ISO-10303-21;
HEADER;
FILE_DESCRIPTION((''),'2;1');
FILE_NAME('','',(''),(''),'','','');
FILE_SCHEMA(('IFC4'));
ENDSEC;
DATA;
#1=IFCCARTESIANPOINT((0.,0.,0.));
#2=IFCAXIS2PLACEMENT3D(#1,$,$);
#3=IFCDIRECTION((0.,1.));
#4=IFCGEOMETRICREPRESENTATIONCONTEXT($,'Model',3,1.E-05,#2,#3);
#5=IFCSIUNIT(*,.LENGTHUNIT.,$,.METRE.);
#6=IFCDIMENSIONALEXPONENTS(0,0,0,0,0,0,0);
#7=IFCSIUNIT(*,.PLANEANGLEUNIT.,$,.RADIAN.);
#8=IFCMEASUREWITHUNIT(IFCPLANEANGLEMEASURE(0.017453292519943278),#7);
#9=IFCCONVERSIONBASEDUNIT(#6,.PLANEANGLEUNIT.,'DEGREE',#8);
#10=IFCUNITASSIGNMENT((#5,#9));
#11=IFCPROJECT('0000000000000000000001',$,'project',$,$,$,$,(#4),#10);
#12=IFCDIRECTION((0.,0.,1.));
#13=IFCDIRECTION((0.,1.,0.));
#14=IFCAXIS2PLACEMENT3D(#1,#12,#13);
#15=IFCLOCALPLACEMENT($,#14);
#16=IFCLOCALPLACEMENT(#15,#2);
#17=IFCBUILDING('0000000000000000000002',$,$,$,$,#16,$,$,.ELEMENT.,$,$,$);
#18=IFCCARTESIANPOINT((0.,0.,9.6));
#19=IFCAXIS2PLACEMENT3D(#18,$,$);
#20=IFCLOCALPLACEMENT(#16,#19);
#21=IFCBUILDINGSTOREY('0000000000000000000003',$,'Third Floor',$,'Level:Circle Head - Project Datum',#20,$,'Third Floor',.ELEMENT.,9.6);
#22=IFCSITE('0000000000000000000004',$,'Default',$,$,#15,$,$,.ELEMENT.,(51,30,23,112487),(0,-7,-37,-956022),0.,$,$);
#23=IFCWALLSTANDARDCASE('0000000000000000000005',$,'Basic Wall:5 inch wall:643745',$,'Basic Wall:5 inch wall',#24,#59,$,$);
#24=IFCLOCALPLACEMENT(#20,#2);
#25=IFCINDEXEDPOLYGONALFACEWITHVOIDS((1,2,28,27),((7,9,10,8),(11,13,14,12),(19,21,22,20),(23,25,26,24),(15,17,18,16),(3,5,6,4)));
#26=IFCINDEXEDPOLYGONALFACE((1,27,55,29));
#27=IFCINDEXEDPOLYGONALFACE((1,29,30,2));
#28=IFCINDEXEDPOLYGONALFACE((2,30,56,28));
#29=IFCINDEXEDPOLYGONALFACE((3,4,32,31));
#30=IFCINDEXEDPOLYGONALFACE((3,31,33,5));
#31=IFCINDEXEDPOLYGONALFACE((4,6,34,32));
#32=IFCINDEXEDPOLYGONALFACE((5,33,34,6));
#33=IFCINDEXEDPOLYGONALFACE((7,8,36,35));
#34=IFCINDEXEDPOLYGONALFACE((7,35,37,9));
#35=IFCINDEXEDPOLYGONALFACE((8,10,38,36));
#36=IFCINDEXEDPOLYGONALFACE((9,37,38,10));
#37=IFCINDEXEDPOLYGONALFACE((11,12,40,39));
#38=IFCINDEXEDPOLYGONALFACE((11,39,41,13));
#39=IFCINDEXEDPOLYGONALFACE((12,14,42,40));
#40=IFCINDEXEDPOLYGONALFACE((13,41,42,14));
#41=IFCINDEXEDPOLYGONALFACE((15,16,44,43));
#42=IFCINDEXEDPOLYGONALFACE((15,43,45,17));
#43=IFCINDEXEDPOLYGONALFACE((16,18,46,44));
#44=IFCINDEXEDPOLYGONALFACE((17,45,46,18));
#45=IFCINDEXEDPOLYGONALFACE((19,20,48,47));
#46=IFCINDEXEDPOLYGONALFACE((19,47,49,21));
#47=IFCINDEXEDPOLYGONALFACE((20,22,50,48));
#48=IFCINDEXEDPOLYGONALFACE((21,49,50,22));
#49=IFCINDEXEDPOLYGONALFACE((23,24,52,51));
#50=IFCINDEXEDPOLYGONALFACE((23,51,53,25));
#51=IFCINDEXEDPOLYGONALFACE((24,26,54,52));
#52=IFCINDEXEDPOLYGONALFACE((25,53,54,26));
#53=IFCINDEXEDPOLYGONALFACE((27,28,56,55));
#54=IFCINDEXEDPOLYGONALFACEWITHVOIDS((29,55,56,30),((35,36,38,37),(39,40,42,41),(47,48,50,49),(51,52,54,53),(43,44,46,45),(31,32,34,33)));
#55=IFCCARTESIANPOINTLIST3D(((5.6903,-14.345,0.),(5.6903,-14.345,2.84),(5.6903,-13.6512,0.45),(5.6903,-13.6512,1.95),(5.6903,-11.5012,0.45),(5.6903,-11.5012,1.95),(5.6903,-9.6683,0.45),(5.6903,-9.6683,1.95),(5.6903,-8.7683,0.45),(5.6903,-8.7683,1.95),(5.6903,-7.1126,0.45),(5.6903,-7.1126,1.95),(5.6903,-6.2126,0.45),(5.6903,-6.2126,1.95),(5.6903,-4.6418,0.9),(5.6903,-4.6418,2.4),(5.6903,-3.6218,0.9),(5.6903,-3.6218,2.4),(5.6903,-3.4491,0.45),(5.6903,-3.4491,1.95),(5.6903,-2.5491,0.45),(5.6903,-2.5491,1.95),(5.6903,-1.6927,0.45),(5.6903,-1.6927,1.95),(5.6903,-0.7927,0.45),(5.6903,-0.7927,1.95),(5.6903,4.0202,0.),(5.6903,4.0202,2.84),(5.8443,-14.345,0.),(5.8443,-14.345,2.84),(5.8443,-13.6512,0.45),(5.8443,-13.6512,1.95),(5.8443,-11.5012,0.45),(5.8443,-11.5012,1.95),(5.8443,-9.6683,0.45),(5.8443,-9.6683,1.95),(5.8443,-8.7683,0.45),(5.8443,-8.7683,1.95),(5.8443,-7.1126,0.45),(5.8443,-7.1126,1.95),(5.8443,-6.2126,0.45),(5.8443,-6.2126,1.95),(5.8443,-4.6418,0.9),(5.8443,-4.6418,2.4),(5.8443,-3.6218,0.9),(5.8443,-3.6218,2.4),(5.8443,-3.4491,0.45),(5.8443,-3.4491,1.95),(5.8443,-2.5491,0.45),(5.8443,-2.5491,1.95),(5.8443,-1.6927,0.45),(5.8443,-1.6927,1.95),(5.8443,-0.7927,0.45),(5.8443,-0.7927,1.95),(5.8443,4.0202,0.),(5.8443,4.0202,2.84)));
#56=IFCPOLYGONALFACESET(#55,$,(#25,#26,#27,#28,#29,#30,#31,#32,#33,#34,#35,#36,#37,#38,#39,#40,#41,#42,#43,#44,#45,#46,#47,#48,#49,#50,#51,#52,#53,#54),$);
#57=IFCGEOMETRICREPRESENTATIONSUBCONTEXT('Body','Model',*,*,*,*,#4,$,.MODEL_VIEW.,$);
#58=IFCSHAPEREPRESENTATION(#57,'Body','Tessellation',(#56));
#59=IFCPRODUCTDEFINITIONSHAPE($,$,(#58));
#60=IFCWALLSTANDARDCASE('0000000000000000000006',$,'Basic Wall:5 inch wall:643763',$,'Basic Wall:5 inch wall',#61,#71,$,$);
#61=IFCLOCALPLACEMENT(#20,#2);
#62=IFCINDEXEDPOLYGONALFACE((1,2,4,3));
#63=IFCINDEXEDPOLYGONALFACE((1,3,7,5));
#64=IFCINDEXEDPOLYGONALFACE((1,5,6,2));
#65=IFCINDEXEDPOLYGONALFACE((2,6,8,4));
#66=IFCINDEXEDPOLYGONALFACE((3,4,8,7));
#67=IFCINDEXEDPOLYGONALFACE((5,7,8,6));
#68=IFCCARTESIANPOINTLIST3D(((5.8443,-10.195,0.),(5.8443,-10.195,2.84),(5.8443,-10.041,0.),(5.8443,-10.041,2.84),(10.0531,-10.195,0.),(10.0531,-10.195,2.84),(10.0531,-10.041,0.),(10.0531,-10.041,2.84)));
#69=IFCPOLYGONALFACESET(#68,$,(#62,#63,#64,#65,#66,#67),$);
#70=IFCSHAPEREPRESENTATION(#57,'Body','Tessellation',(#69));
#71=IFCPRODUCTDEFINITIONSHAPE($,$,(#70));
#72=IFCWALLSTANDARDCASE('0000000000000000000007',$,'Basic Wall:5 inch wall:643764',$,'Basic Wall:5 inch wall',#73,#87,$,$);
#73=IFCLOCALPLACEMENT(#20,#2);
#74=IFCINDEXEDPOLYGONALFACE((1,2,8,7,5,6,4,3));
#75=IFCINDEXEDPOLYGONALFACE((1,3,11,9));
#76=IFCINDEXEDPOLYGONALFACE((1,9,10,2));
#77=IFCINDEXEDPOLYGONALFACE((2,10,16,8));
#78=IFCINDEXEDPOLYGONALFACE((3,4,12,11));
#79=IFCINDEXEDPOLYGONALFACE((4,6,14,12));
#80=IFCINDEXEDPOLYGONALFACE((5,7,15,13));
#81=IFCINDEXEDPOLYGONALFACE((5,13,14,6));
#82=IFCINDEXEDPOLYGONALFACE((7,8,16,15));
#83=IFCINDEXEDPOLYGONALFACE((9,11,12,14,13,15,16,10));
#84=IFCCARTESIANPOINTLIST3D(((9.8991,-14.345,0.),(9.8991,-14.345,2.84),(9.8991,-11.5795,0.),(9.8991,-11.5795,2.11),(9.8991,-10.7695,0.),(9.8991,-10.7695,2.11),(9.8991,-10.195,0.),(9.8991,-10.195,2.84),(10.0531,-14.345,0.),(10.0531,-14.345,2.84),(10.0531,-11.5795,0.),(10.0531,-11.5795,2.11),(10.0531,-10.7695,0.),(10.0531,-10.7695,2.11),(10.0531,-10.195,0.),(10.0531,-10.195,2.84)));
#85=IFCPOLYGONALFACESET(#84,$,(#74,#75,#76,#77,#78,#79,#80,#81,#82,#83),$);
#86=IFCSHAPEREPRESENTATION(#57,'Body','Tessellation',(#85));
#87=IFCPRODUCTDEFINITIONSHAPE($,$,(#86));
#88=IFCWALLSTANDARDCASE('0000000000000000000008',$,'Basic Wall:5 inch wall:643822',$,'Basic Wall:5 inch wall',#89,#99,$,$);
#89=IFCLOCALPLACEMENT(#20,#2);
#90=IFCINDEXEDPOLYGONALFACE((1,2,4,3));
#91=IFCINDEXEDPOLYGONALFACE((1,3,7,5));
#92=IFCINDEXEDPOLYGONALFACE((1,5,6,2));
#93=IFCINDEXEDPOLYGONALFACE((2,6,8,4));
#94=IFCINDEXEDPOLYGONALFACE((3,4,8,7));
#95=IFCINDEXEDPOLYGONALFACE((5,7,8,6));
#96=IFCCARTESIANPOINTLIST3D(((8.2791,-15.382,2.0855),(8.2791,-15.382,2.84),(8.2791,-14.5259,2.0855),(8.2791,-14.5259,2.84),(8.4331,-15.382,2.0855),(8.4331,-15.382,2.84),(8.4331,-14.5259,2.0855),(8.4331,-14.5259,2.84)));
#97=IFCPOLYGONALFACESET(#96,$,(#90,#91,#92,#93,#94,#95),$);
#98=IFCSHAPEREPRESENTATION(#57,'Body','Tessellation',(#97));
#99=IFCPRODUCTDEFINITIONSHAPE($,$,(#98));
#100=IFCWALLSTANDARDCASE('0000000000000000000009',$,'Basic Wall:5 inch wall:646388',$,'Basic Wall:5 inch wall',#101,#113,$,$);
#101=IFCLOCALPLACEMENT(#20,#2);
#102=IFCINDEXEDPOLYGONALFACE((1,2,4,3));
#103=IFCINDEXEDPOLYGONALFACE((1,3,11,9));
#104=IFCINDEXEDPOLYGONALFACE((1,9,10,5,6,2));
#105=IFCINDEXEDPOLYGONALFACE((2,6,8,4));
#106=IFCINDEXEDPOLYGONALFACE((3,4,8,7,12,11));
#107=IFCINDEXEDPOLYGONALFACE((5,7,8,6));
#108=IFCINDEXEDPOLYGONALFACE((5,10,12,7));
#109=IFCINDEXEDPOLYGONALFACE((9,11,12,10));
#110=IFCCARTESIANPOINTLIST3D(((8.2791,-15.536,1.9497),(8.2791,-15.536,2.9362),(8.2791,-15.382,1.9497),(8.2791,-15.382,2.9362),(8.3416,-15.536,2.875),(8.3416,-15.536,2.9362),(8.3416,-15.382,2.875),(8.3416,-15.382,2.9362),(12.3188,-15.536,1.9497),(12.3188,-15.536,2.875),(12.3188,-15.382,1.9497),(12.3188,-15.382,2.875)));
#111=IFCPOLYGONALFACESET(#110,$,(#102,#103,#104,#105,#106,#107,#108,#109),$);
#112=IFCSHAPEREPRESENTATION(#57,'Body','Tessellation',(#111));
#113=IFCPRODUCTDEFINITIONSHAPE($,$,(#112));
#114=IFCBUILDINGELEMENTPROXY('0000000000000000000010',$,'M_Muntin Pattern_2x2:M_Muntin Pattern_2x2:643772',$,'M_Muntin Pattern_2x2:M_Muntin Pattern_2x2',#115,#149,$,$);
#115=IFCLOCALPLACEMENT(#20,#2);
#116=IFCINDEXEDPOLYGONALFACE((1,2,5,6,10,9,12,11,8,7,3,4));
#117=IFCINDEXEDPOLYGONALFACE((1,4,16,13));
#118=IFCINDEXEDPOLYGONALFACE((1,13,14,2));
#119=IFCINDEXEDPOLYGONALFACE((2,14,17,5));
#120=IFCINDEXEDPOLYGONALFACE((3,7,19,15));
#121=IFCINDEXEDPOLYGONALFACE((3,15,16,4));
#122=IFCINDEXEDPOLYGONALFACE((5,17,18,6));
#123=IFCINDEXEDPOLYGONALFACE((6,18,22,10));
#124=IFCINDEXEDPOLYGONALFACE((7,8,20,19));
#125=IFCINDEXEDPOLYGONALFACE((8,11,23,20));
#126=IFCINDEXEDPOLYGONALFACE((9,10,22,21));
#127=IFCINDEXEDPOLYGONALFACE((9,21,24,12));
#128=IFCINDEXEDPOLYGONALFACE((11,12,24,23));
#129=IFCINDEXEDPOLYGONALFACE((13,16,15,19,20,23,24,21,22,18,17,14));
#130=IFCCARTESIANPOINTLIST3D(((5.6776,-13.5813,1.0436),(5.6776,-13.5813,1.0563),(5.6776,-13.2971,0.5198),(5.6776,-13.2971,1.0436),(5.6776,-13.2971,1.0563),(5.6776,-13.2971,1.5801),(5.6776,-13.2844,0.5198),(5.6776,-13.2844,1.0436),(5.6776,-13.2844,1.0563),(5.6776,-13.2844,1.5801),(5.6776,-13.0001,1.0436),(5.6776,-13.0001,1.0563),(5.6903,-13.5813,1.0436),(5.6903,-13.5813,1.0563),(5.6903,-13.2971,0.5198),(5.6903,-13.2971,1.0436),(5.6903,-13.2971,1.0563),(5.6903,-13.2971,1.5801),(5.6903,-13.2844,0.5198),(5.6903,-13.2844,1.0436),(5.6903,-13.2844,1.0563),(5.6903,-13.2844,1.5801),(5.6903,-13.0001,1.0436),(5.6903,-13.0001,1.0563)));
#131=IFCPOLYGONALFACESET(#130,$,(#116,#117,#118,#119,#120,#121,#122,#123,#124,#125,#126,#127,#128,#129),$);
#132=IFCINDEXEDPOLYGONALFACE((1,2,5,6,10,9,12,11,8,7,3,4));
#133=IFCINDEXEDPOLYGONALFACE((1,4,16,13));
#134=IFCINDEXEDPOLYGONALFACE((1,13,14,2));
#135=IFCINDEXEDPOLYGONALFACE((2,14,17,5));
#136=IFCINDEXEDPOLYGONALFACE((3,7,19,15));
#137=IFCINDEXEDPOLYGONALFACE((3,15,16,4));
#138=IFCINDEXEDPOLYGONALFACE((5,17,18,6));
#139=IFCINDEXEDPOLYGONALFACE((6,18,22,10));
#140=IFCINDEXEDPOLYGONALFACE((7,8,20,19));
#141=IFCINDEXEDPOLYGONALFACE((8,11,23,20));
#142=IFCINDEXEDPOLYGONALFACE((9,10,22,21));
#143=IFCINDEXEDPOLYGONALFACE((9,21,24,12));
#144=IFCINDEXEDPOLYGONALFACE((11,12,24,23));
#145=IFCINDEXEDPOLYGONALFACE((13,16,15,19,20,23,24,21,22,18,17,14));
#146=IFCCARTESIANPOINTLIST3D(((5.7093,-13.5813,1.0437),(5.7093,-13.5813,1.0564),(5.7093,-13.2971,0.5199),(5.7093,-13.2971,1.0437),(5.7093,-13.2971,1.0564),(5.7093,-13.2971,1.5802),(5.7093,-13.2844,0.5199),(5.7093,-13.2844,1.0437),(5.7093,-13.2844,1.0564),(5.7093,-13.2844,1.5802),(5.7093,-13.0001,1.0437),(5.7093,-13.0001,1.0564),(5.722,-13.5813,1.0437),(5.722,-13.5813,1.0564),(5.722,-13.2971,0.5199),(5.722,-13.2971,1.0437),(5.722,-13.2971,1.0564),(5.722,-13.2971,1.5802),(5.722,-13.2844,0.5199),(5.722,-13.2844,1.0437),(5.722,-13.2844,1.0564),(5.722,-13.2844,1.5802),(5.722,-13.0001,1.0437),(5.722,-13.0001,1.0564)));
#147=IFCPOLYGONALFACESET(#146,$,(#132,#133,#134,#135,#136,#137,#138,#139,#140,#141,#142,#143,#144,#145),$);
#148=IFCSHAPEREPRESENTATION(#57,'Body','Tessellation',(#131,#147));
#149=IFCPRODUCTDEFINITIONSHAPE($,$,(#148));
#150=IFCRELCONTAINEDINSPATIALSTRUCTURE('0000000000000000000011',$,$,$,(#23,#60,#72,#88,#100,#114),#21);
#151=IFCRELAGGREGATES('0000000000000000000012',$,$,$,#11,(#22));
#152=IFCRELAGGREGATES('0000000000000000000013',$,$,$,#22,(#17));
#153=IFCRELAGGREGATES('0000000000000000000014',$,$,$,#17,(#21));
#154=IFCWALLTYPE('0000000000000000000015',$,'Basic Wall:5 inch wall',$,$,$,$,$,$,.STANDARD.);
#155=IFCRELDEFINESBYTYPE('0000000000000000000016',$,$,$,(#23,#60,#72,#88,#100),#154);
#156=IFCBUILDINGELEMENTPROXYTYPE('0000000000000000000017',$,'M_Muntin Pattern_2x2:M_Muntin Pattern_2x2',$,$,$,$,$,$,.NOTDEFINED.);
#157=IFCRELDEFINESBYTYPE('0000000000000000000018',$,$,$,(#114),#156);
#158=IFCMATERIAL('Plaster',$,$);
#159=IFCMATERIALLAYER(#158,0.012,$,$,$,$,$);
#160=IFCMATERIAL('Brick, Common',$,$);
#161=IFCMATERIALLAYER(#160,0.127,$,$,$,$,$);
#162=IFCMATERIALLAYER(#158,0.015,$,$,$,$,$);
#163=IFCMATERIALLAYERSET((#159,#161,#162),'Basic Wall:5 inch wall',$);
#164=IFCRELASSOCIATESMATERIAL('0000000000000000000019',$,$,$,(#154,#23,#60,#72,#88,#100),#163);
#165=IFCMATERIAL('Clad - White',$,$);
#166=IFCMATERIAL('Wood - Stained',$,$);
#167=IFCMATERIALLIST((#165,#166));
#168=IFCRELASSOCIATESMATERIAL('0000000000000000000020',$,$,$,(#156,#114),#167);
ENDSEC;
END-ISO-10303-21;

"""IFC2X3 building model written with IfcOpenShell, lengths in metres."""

from ifc_helpers import new_model, entity, si_unit, converted_unit, direction, frame, frame_2d, origin, place, context, subcontext, project, spatial, polyline, rectangle, outline, extrude, clip, bounded_halfspace, source, transform, mapped, material, material_list, layer, layer_set, layer_usage, type_object, type_shapes, element, save


model = new_model("IFC2X3")

# Units and contexts
model_context = context("Model", 3, precision=1e-05, world=origin(), true_north=direction((0.0, 1.0)))
body_context = subcontext(model_context, "Body", "Model", "MODEL_VIEW")
ifc_project = project(units=[si_unit("LENGTHUNIT", "METRE"), converted_unit("PLANEANGLEUNIT", "DEGREE", entity("IfcPlaneAngleMeasure", 0.017453292519943278), si_unit("PLANEANGLEUNIT", "RADIAN"), dimensions=[0, 0, 0, 0, 0, 0, 0])], contexts=[model_context])

# Site, building, storey
site_placement = place(None, frame((0.0, 0.0, 0.0), z_axis=(0.0, 0.0, 1.0), x_axis=(0.0, 1.0, 0.0)))
site = spatial("IfcSite", under=ifc_project, at=site_placement, Name="Default", CompositionType="ELEMENT", RefLatitude=(51, 30, 23, 112487), RefLongitude=(0, -7, -37, -956022), RefElevation=0.0)
building_placement = place(site_placement, origin())
building = spatial("IfcBuilding", under=site, at=building_placement, CompositionType="ELEMENT")
storey_placement = place(building_placement, frame((0.0, 0.0, 9.6)))
storey = spatial("IfcBuildingStorey", under=building, at=storey_placement, Name="Third Floor", ObjectType="Level:Circle Head - Project Datum", LongName="Third Floor", CompositionType="ELEMENT", Elevation=9.6)

# Wall, openings
ifc_material_1 = material(Name="Plaster")
ifc_layer_1 = layer(ifc_material_1, 0.012)
ifc_material_2 = material(Name="Brick, Common")
ifc_layer_2 = layer(ifc_material_2, 0.127)
ifc_layer_3 = layer(ifc_material_1, 0.015)
ifc_layer_set = layer_set([ifc_layer_1, ifc_layer_2, ifc_layer_3], Name="Basic Wall:5 inch wall")
ifc_layer_usage_1 = layer_usage(ifc_layer_set, "AXIS2", "NEGATIVE", 0.077)
wall_type = type_object("IfcWallType", Name="Basic Wall:5 inch wall", PredefinedType="STANDARD", material=ifc_layer_set)
wall_1_placement = place(storey_placement, frame((5.7673, -14.345, 0.0), z_axis=(0.0, 0.0, 1.0), x_axis=(0.0, 1.0, 0.0)))
wall_1 = element("IfcWallStandardCase", 1, at=wall_1_placement, inside=storey, type_object=wall_type, material=ifc_layer_usage_1, Name="Basic Wall:5 inch wall:643745", ObjectType="Basic Wall:5 inch wall", context=body_context, shape_type="SweptSolid", body=[
    extrude(rectangle(XDim=18.3652, YDim=0.154, at=frame_2d((9.1826, 0.0), x_axis=(-1.0, 0.0))), origin(), (0.0, 0.0, 1.0), 2.84),
])
opening_1_placement = place(wall_1_placement, frame((0.6938, -0.077, 0.45)))
element("IfcOpeningElement", 2, at=opening_1_placement, cuts=wall_1, ObjectType="Opening", context=body_context, shape_type="SweptSolid", body=[
    extrude(rectangle(XDim=1.5, YDim=2.15, at=frame_2d((0.75, 1.075), x_axis=(-1.0, 0.0))), frame((0.0, 0.0, 0.0), z_axis=(0.0, 1.0, 0.0), x_axis=(0.0, 0.0, 1.0)), (0.0, 0.0, 1.0), 0.154),
])
opening_2_placement = place(wall_1_placement, frame((4.6767, -0.077, 0.45)))
element("IfcOpeningElement", 3, at=opening_2_placement, cuts=wall_1, ObjectType="Opening", context=body_context, shape_type="SweptSolid", body=[
    extrude(rectangle(XDim=1.5, YDim=0.9, at=frame_2d((0.75, 0.45), x_axis=(-1.0, 0.0))), frame((0.0, 0.0, 0.0), z_axis=(0.0, 1.0, 0.0), x_axis=(0.0, 0.0, 1.0)), (0.0, 0.0, 1.0), 0.154),
])
opening_3_placement = place(wall_1_placement, frame((7.2323, -0.077, 0.45)))
element("IfcOpeningElement", 4, at=opening_3_placement, cuts=wall_1, ObjectType="Opening", context=body_context, shape_type="SweptSolid", body=[
    extrude(rectangle(XDim=1.5, YDim=0.9, at=frame_2d((0.75, 0.45), x_axis=(-1.0, 0.0))), frame((0.0, 0.0, 0.0), z_axis=(0.0, 1.0, 0.0), x_axis=(0.0, 0.0, 1.0)), (0.0, 0.0, 1.0), 0.154),
])
opening_4_placement = place(wall_1_placement, frame((10.8959, -0.077, 0.45)))
element("IfcOpeningElement", 5, at=opening_4_placement, cuts=wall_1, ObjectType="Opening", context=body_context, shape_type="SweptSolid", body=[
    extrude(rectangle(XDim=1.5, YDim=0.9, at=frame_2d((0.75, 0.45), x_axis=(-1.0, 0.0))), frame((0.0, 0.0, 0.0), z_axis=(0.0, 1.0, 0.0), x_axis=(0.0, 0.0, 1.0)), (0.0, 0.0, 1.0), 0.154),
])
opening_5_placement = place(wall_1_placement, frame((12.6523, -0.077, 0.45)))
element("IfcOpeningElement", 6, at=opening_5_placement, cuts=wall_1, ObjectType="Opening", context=body_context, shape_type="SweptSolid", body=[
    extrude(rectangle(XDim=1.5, YDim=0.9, at=frame_2d((0.75, 0.45), x_axis=(-1.0, 0.0))), frame((0.0, 0.0, 0.0), z_axis=(0.0, 1.0, 0.0), x_axis=(0.0, 0.0, 1.0)), (0.0, 0.0, 1.0), 0.154),
])
opening_6_placement = place(wall_1_placement, frame((9.7032, -0.077, 0.9)))
element("IfcOpeningElement", 7, at=opening_6_placement, cuts=wall_1, ObjectType="Opening", context=body_context, shape_type="SweptSolid", body=[
    extrude(rectangle(XDim=1.5, YDim=1.02, at=frame_2d((0.75, 0.51), x_axis=(-1.0, 0.0))), frame((0.0, 0.0, 0.0), z_axis=(0.0, 1.0, 0.0), x_axis=(0.0, 0.0, 1.0)), (0.0, 0.0, 1.0), 0.154),
])

# Wall
ifc_layer_usage_2 = layer_usage(ifc_layer_set, "AXIS2", "POSITIVE", -0.077)
wall_2_placement = place(storey_placement, frame((5.8443, -10.118, 0.0)))
element("IfcWallStandardCase", 8, at=wall_2_placement, inside=storey, type_object=wall_type, material=ifc_layer_usage_2, Name="Basic Wall:5 inch wall:643763", ObjectType="Basic Wall:5 inch wall", context=body_context, shape_type="SweptSolid", body=[
    extrude(rectangle(XDim=4.2088, YDim=0.154, at=frame_2d((2.1044, 0.0), x_axis=(-1.0, 0.0))), origin(), (0.0, 0.0, 1.0), 2.84),
])

# Wall, opening
ifc_layer_usage_3 = layer_usage(ifc_layer_set, "AXIS2", "NEGATIVE", 0.077)
wall_3_placement = place(storey_placement, frame((9.9761, -10.195, 0.0), z_axis=(0.0, 0.0, 1.0), x_axis=(0.0, -1.0, 0.0)))
wall_3 = element("IfcWallStandardCase", 9, at=wall_3_placement, inside=storey, type_object=wall_type, material=ifc_layer_usage_3, Name="Basic Wall:5 inch wall:643764", ObjectType="Basic Wall:5 inch wall", context=body_context, shape_type="SweptSolid", body=[
    extrude(rectangle(XDim=4.15, YDim=0.154, at=frame_2d((2.075, 0.0), x_axis=(1.0, 0.0))), origin(), (0.0, 0.0, 1.0), 2.84),
])
opening_7_placement = place(wall_3_placement, frame((1.3845, 0.077, 0.0)))
element("IfcOpeningElement", 10, at=opening_7_placement, cuts=wall_3, ObjectType="Opening", context=body_context, shape_type="SweptSolid", body=[
    extrude(rectangle(XDim=2.11, YDim=0.81, at=frame_2d((1.055, 0.405), x_axis=(1.0, 0.0))), frame((0.0, 0.0, 0.0), z_axis=(0.0, -1.0, 0.0), x_axis=(0.0, 0.0, 1.0)), (0.0, 0.0, 1.0), 0.154),
])

# Walls
ifc_layer_usage_4 = layer_usage(ifc_layer_set, "AXIS2", "NEGATIVE", 0.077)
wall_4_placement = place(storey_placement, frame((8.3561, -14.5259, 2.0855), z_axis=(0.0, 0.0, 1.0), x_axis=(0.0, -1.0, 0.0)))
element("IfcWallStandardCase", 11, at=wall_4_placement, inside=storey, type_object=wall_type, material=ifc_layer_usage_4, Name="Basic Wall:5 inch wall:643822", ObjectType="Basic Wall:5 inch wall", context=body_context, shape_type="SweptSolid", body=[
    extrude(rectangle(XDim=0.8561, YDim=0.154, at=frame_2d((0.4281, 0.0), x_axis=(-1.0, 0.0))), origin(), (0.0, 0.0, 1.0), 0.7545),
])
ifc_layer_usage_5 = layer_usage(ifc_layer_set, "AXIS2", "NEGATIVE", 0.077)
wall_5_placement = place(storey_placement, frame((8.2791, -15.459, 1.9497)))
element("IfcWallStandardCase", 12, at=wall_5_placement, inside=storey, type_object=wall_type, material=ifc_layer_usage_5, Name="Basic Wall:5 inch wall:646388", ObjectType="Basic Wall:5 inch wall", context=body_context, shape_type="Clipping", body=[
    clip(extrude(rectangle(XDim=4.0398, YDim=0.154, at=frame_2d((2.0199, 0.0), x_axis=(-1.0, 0.0))), origin(), (0.0, 0.0, 1.0), 0.9865), bounded_halfspace(frame((0.0626, -0.077, 0.9253), z_axis=(0.0, 0.0, -1.0), x_axis=(0.0, -1.0, 0.0)), True, frame((0.0626, -0.077, 0.9253)), polyline([(0.0, 0.0), (3.9772, 0.0), (3.9772, 0.154), (0.0, 0.154), (0.0, 0.0)]))),
])

# Building element proxy
ifc_material_3 = material(Name="Clad - White")
ifc_material_4 = material(Name="Wood - Stained")
ifc_material_list = material_list([ifc_material_3, ifc_material_4])
building_element_proxy_type_1 = type_object("IfcBuildingElementProxyType", Name="M_Muntin Pattern_2x2:M_Muntin Pattern_2x2", PredefinedType="NOTDEFINED", material=ifc_material_list)
shared_shape_1 = source(origin(), body_context, "Body", "SweptSolid", [
    extrude(outline(polyline([(0.0064, -0.0064), (0.5301, -0.0064), (0.5301, 0.0063), (0.0064, 0.0063), (0.0064, 0.2906), (-0.0063, 0.2906), (-0.0063, 0.0063), (-0.5302, 0.0063), (-0.5302, -0.0064), (-0.0063, -0.0064), (-0.0063, -0.2906), (0.0064, -0.2906), (0.0064, -0.0064)])), frame((0.0, 0.0095, 0.5301), z_axis=(0.0, 1.0, 0.0), x_axis=(0.0, 0.0, 1.0)), (0.0, 0.0, 1.0), 0.0127),
    extrude(outline(polyline([(0.0064, -0.0064), (0.5302, -0.0064), (0.5302, 0.0063), (0.0064, 0.0063), (0.0064, 0.2906), (-0.0063, 0.2906), (-0.0063, 0.0063), (-0.5302, 0.0063), (-0.5302, -0.0064), (-0.0063, -0.0064), (-0.0063, -0.2906), (0.0064, -0.2906), (0.0064, -0.0064)])), frame((0.0, -0.0222, 0.5302), z_axis=(0.0, 1.0, 0.0), x_axis=(0.0, 0.0, 1.0)), (0.0, 0.0, 1.0), 0.0127),
])
type_shapes(building_element_proxy_type_1, [shared_shape_1])
proxy_1_placement = place(storey_placement, frame((5.6998, -13.2907, 0.5199), z_axis=(0.0, 0.0, 1.0), x_axis=(0.0, 1.0, 0.0)))
element("IfcBuildingElementProxy", 13, at=proxy_1_placement, inside=storey, type_object=building_element_proxy_type_1, material=ifc_material_list, Name="M_Muntin Pattern_2x2:M_Muntin Pattern_2x2:643772", ObjectType="M_Muntin Pattern_2x2:M_Muntin Pattern_2x2", context=body_context, shape_type="MappedRepresentation", body=[
    mapped(shared_shape_1, transform((0.0, 0.0, 0.0), scale=1.0)),
])

save(model, "model.ifc")
